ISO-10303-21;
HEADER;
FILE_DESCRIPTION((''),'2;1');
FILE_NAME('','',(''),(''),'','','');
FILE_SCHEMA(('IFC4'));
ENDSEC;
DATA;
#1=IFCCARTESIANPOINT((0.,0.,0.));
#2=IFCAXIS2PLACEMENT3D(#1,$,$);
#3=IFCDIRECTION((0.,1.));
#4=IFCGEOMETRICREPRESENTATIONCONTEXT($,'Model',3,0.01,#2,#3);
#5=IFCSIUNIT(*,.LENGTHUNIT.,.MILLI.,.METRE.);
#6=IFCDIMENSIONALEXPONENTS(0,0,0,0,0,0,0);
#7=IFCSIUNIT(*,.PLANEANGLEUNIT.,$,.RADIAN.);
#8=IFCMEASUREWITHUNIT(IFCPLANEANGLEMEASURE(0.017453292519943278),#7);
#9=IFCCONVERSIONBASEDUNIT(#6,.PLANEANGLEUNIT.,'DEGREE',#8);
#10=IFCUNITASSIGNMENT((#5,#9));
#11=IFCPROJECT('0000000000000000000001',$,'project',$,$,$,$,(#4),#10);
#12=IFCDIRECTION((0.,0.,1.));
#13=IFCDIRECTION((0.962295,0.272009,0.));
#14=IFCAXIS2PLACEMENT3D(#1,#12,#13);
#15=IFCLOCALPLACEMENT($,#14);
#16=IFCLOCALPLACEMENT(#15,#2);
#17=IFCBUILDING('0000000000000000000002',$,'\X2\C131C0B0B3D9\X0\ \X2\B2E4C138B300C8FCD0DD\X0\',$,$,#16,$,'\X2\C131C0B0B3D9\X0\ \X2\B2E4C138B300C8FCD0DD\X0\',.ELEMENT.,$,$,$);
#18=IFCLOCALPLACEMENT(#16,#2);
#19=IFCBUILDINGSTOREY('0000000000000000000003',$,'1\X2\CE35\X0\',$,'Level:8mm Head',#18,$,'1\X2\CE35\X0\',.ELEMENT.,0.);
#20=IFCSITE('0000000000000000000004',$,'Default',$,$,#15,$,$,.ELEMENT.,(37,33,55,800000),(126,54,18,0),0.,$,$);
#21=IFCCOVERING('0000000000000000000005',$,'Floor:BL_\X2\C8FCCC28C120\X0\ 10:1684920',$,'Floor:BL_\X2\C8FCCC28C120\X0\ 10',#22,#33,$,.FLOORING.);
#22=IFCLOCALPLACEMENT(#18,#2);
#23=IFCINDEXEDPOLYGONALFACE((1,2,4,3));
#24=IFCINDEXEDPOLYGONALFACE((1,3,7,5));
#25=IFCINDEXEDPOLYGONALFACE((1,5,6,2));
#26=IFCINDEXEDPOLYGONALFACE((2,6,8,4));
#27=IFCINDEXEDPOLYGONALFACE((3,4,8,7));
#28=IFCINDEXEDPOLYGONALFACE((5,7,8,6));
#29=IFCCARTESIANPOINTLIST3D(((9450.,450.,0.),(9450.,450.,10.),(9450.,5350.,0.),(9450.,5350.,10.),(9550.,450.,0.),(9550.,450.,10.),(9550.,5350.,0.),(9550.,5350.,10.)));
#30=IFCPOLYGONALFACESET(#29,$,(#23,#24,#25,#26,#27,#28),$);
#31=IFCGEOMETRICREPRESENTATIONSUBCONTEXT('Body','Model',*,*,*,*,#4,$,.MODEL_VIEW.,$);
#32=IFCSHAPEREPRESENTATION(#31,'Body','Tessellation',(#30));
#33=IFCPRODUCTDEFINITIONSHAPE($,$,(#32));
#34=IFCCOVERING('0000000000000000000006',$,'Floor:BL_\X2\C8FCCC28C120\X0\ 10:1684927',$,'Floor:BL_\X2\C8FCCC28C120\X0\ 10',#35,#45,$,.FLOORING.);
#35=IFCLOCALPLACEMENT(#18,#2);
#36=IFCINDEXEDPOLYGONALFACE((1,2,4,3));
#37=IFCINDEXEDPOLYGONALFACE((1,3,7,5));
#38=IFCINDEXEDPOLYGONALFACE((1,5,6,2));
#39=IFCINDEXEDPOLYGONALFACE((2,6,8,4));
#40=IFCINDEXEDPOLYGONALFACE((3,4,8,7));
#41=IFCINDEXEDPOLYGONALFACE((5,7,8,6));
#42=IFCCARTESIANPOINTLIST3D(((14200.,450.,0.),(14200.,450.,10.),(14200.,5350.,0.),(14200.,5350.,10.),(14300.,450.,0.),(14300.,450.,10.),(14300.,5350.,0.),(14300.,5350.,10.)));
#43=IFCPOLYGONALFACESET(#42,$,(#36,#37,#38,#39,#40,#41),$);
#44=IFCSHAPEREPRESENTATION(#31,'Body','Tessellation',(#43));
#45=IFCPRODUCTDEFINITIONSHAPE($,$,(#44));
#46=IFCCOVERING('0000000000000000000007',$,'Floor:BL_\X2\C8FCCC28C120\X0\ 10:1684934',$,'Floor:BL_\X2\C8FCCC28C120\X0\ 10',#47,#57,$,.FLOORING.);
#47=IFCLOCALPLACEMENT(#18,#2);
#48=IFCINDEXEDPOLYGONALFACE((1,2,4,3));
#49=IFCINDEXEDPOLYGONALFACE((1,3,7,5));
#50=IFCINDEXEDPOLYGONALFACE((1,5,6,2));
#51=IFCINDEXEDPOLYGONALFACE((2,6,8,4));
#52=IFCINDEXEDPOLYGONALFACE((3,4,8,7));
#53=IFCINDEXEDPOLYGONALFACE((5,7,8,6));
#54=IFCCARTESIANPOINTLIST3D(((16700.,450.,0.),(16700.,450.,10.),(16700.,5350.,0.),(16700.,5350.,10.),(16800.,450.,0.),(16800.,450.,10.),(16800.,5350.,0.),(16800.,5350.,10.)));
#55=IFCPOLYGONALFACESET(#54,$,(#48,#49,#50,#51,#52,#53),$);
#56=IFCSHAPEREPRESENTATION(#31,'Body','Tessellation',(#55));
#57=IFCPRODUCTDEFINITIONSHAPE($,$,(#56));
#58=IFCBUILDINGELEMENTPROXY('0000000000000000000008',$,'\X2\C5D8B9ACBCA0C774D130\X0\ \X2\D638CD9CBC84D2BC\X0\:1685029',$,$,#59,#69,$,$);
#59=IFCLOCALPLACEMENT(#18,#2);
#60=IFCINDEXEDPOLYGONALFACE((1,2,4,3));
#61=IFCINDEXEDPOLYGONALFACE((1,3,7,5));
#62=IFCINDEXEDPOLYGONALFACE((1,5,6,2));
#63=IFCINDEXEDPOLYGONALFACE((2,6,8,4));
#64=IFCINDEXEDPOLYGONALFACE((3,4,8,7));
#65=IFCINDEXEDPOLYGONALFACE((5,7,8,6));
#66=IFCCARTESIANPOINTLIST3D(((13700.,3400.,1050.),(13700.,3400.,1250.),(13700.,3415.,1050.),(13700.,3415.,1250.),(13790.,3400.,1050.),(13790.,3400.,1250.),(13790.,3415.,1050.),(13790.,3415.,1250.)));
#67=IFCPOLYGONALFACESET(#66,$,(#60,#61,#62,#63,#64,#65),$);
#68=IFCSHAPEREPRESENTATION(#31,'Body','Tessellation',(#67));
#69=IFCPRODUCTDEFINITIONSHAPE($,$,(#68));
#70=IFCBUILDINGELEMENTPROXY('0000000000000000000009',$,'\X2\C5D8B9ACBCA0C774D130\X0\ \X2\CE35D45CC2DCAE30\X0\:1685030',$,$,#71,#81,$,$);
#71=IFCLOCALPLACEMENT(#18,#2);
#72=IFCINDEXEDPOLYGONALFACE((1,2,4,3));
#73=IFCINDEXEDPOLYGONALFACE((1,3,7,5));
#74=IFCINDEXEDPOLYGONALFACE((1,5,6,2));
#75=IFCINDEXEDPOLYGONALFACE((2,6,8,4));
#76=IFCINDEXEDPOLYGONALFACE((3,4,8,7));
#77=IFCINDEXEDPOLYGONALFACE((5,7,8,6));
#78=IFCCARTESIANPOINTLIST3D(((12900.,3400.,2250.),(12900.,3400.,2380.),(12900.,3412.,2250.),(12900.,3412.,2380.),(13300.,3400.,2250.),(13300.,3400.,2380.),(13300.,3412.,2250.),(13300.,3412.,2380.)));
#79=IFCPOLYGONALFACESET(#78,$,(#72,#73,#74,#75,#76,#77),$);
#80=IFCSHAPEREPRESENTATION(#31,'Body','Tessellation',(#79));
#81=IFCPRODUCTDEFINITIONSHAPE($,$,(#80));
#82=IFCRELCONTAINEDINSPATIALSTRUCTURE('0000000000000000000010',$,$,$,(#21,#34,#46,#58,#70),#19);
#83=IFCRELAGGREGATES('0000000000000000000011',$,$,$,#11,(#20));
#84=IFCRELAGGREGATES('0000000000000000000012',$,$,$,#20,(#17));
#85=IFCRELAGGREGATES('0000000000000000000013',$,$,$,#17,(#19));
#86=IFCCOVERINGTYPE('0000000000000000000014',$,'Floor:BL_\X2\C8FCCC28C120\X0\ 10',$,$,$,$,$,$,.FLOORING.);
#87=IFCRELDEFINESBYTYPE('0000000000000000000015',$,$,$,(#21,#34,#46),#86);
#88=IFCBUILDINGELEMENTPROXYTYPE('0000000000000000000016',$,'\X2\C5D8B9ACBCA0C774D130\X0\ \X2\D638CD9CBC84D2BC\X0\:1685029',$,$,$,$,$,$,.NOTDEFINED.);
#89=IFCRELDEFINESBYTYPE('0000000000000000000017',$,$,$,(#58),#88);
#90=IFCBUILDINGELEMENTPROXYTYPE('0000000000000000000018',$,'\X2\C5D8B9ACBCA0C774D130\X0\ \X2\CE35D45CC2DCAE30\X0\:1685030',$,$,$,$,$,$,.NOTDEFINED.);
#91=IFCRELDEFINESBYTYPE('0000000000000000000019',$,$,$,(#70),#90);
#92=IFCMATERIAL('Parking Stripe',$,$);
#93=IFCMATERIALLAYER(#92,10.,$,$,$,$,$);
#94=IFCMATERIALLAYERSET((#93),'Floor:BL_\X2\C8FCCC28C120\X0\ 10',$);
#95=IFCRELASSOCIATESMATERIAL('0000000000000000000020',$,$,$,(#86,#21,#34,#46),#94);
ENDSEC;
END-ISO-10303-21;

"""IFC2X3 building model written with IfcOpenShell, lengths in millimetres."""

from ifc_helpers import new_model, entity, si_unit, converted_unit, direction, frame, frame_2d, origin, origin_2d_with_axis, place, context, subcontext, project, spatial, rectangle, extrude, material, layer, layer_set, layer_usage, type_object, element, save


model = new_model("IFC2X3")

# Units and contexts
model_context = context("Model", 3, precision=0.01, world=origin(), true_north=direction((0.0, 1.0)))
body_context = subcontext(model_context, "Body", "Model", "MODEL_VIEW")
ifc_project = project(units=[si_unit("LENGTHUNIT", "METRE", prefix="MILLI"), converted_unit("PLANEANGLEUNIT", "DEGREE", entity("IfcPlaneAngleMeasure", 0.017453292519943278), si_unit("PLANEANGLEUNIT", "RADIAN"), dimensions=[0, 0, 0, 0, 0, 0, 0])], contexts=[model_context])

# Site, building, storey
site_placement = place(None, frame((0.0, 0.0, 0.0), z_axis=(0.0, 0.0, 1.0), x_axis=(0.962295, 0.272009, 0.0)))
site = spatial("IfcSite", under=ifc_project, at=site_placement, Name="Default", CompositionType="ELEMENT", RefLatitude=(37, 33, 55, 800000), RefLongitude=(126, 54, 18, 0), RefElevation=0.0)
building_placement = place(site_placement, origin())
building = spatial("IfcBuilding", under=site, at=building_placement, Name="성산동 다세대주택", LongName="성산동 다세대주택", CompositionType="ELEMENT")
storey_placement = place(building_placement, origin())
storey = spatial("IfcBuildingStorey", under=building, at=storey_placement, Name="1층", ObjectType="Level:8mm Head", LongName="1층", CompositionType="ELEMENT", Elevation=0.0)

# Coverings
ifc_material_1 = material(Name="Parking Stripe")
ifc_layer_1 = layer(ifc_material_1, 10.0)
ifc_layer_set_1 = layer_set([ifc_layer_1], Name="Floor:BL_주차선 10")
covering_type = type_object("IfcCoveringType", Name="Floor:BL_주차선 10", PredefinedType="FLOORING", material=ifc_layer_set_1)
ifc_layer_usage_1 = layer_usage(ifc_layer_set_1, "AXIS3", "POSITIVE", 0.0)
covering_1_placement = place(storey_placement, origin())
element("IfcCovering", 1, at=covering_1_placement, inside=storey, type_object=covering_type, material=ifc_layer_usage_1, Name="Floor:BL_주차선 10:1684920", ObjectType="Floor:BL_주차선 10", PredefinedType="FLOORING", context=body_context, shape_type="SweptSolid", body=[
    extrude(rectangle(XDim=4900.0, YDim=100.0, at=frame_2d((0.0, 0.0), x_axis=(1.0, 0.0))), frame((9500.0, 2900.0, 10.0), z_axis=(0.0, 0.0, -1.0), x_axis=(0.0, 1.0, 0.0)), (0.0, 0.0, 1.0), 10.0),
])
ifc_layer_usage_2 = layer_usage(ifc_layer_set_1, "AXIS3", "POSITIVE", 0.0)
covering_2_placement = place(storey_placement, origin())
element("IfcCovering", 2, at=covering_2_placement, inside=storey, type_object=covering_type, material=ifc_layer_usage_2, Name="Floor:BL_주차선 10:1684927", ObjectType="Floor:BL_주차선 10", PredefinedType="FLOORING", context=body_context, shape_type="SweptSolid", body=[
    extrude(rectangle(XDim=4900.0, YDim=100.0, at=origin_2d_with_axis()), frame((14250.0, 2900.0, 10.0), z_axis=(0.0, 0.0, -1.0), x_axis=(0.0, 1.0, 0.0)), (0.0, 0.0, 1.0), 10.0),
])
ifc_layer_usage_3 = layer_usage(ifc_layer_set_1, "AXIS3", "POSITIVE", 0.0)
covering_3_placement = place(storey_placement, origin())
element("IfcCovering", 3, at=covering_3_placement, inside=storey, type_object=covering_type, material=ifc_layer_usage_3, Name="Floor:BL_주차선 10:1684934", ObjectType="Floor:BL_주차선 10", PredefinedType="FLOORING", context=body_context, shape_type="SweptSolid", body=[
    extrude(rectangle(XDim=4900.0, YDim=100.0, at=origin_2d_with_axis()), frame((16750.0, 2900.0, 10.0), z_axis=(0.0, 0.0, -1.0), x_axis=(0.0, 1.0, 0.0)), (0.0, 0.0, 1.0), 10.0),
])

# Building element proxies
building_element_proxy_type_1 = type_object("IfcBuildingElementProxyType", Name="엘리베이터 호출버튼:1685029", PredefinedType="NOTDEFINED")
proxy_1_placement = place(storey_placement, origin())
element("IfcBuildingElementProxy", 4, at=proxy_1_placement, inside=storey, type_object=building_element_proxy_type_1, Name="엘리베이터 호출버튼:1685029", context=body_context, shape_type="SweptSolid", body=[
    extrude(rectangle(XDim=90.0, YDim=15.0, at=frame_2d((0.0, 0.0), x_axis=(1.0, 0.0))), frame((13745.0, 3407.5, 1050.0)), (0.0, 0.0, 1.0), 200.0),
])
building_element_proxy_type_2 = type_object("IfcBuildingElementProxyType", Name="엘리베이터 층표시기:1685030", PredefinedType="NOTDEFINED")
proxy_2_placement = place(storey_placement, origin())
element("IfcBuildingElementProxy", 5, at=proxy_2_placement, inside=storey, type_object=building_element_proxy_type_2, Name="엘리베이터 층표시기:1685030", context=body_context, shape_type="SweptSolid", body=[
    extrude(rectangle(XDim=400.0, YDim=12.0, at=frame_2d((0.0, 0.0), x_axis=(1.0, 0.0))), frame((13100.0, 3406.0, 2250.0)), (0.0, 0.0, 1.0), 130.0),
])

save(model, "model.ifc")
